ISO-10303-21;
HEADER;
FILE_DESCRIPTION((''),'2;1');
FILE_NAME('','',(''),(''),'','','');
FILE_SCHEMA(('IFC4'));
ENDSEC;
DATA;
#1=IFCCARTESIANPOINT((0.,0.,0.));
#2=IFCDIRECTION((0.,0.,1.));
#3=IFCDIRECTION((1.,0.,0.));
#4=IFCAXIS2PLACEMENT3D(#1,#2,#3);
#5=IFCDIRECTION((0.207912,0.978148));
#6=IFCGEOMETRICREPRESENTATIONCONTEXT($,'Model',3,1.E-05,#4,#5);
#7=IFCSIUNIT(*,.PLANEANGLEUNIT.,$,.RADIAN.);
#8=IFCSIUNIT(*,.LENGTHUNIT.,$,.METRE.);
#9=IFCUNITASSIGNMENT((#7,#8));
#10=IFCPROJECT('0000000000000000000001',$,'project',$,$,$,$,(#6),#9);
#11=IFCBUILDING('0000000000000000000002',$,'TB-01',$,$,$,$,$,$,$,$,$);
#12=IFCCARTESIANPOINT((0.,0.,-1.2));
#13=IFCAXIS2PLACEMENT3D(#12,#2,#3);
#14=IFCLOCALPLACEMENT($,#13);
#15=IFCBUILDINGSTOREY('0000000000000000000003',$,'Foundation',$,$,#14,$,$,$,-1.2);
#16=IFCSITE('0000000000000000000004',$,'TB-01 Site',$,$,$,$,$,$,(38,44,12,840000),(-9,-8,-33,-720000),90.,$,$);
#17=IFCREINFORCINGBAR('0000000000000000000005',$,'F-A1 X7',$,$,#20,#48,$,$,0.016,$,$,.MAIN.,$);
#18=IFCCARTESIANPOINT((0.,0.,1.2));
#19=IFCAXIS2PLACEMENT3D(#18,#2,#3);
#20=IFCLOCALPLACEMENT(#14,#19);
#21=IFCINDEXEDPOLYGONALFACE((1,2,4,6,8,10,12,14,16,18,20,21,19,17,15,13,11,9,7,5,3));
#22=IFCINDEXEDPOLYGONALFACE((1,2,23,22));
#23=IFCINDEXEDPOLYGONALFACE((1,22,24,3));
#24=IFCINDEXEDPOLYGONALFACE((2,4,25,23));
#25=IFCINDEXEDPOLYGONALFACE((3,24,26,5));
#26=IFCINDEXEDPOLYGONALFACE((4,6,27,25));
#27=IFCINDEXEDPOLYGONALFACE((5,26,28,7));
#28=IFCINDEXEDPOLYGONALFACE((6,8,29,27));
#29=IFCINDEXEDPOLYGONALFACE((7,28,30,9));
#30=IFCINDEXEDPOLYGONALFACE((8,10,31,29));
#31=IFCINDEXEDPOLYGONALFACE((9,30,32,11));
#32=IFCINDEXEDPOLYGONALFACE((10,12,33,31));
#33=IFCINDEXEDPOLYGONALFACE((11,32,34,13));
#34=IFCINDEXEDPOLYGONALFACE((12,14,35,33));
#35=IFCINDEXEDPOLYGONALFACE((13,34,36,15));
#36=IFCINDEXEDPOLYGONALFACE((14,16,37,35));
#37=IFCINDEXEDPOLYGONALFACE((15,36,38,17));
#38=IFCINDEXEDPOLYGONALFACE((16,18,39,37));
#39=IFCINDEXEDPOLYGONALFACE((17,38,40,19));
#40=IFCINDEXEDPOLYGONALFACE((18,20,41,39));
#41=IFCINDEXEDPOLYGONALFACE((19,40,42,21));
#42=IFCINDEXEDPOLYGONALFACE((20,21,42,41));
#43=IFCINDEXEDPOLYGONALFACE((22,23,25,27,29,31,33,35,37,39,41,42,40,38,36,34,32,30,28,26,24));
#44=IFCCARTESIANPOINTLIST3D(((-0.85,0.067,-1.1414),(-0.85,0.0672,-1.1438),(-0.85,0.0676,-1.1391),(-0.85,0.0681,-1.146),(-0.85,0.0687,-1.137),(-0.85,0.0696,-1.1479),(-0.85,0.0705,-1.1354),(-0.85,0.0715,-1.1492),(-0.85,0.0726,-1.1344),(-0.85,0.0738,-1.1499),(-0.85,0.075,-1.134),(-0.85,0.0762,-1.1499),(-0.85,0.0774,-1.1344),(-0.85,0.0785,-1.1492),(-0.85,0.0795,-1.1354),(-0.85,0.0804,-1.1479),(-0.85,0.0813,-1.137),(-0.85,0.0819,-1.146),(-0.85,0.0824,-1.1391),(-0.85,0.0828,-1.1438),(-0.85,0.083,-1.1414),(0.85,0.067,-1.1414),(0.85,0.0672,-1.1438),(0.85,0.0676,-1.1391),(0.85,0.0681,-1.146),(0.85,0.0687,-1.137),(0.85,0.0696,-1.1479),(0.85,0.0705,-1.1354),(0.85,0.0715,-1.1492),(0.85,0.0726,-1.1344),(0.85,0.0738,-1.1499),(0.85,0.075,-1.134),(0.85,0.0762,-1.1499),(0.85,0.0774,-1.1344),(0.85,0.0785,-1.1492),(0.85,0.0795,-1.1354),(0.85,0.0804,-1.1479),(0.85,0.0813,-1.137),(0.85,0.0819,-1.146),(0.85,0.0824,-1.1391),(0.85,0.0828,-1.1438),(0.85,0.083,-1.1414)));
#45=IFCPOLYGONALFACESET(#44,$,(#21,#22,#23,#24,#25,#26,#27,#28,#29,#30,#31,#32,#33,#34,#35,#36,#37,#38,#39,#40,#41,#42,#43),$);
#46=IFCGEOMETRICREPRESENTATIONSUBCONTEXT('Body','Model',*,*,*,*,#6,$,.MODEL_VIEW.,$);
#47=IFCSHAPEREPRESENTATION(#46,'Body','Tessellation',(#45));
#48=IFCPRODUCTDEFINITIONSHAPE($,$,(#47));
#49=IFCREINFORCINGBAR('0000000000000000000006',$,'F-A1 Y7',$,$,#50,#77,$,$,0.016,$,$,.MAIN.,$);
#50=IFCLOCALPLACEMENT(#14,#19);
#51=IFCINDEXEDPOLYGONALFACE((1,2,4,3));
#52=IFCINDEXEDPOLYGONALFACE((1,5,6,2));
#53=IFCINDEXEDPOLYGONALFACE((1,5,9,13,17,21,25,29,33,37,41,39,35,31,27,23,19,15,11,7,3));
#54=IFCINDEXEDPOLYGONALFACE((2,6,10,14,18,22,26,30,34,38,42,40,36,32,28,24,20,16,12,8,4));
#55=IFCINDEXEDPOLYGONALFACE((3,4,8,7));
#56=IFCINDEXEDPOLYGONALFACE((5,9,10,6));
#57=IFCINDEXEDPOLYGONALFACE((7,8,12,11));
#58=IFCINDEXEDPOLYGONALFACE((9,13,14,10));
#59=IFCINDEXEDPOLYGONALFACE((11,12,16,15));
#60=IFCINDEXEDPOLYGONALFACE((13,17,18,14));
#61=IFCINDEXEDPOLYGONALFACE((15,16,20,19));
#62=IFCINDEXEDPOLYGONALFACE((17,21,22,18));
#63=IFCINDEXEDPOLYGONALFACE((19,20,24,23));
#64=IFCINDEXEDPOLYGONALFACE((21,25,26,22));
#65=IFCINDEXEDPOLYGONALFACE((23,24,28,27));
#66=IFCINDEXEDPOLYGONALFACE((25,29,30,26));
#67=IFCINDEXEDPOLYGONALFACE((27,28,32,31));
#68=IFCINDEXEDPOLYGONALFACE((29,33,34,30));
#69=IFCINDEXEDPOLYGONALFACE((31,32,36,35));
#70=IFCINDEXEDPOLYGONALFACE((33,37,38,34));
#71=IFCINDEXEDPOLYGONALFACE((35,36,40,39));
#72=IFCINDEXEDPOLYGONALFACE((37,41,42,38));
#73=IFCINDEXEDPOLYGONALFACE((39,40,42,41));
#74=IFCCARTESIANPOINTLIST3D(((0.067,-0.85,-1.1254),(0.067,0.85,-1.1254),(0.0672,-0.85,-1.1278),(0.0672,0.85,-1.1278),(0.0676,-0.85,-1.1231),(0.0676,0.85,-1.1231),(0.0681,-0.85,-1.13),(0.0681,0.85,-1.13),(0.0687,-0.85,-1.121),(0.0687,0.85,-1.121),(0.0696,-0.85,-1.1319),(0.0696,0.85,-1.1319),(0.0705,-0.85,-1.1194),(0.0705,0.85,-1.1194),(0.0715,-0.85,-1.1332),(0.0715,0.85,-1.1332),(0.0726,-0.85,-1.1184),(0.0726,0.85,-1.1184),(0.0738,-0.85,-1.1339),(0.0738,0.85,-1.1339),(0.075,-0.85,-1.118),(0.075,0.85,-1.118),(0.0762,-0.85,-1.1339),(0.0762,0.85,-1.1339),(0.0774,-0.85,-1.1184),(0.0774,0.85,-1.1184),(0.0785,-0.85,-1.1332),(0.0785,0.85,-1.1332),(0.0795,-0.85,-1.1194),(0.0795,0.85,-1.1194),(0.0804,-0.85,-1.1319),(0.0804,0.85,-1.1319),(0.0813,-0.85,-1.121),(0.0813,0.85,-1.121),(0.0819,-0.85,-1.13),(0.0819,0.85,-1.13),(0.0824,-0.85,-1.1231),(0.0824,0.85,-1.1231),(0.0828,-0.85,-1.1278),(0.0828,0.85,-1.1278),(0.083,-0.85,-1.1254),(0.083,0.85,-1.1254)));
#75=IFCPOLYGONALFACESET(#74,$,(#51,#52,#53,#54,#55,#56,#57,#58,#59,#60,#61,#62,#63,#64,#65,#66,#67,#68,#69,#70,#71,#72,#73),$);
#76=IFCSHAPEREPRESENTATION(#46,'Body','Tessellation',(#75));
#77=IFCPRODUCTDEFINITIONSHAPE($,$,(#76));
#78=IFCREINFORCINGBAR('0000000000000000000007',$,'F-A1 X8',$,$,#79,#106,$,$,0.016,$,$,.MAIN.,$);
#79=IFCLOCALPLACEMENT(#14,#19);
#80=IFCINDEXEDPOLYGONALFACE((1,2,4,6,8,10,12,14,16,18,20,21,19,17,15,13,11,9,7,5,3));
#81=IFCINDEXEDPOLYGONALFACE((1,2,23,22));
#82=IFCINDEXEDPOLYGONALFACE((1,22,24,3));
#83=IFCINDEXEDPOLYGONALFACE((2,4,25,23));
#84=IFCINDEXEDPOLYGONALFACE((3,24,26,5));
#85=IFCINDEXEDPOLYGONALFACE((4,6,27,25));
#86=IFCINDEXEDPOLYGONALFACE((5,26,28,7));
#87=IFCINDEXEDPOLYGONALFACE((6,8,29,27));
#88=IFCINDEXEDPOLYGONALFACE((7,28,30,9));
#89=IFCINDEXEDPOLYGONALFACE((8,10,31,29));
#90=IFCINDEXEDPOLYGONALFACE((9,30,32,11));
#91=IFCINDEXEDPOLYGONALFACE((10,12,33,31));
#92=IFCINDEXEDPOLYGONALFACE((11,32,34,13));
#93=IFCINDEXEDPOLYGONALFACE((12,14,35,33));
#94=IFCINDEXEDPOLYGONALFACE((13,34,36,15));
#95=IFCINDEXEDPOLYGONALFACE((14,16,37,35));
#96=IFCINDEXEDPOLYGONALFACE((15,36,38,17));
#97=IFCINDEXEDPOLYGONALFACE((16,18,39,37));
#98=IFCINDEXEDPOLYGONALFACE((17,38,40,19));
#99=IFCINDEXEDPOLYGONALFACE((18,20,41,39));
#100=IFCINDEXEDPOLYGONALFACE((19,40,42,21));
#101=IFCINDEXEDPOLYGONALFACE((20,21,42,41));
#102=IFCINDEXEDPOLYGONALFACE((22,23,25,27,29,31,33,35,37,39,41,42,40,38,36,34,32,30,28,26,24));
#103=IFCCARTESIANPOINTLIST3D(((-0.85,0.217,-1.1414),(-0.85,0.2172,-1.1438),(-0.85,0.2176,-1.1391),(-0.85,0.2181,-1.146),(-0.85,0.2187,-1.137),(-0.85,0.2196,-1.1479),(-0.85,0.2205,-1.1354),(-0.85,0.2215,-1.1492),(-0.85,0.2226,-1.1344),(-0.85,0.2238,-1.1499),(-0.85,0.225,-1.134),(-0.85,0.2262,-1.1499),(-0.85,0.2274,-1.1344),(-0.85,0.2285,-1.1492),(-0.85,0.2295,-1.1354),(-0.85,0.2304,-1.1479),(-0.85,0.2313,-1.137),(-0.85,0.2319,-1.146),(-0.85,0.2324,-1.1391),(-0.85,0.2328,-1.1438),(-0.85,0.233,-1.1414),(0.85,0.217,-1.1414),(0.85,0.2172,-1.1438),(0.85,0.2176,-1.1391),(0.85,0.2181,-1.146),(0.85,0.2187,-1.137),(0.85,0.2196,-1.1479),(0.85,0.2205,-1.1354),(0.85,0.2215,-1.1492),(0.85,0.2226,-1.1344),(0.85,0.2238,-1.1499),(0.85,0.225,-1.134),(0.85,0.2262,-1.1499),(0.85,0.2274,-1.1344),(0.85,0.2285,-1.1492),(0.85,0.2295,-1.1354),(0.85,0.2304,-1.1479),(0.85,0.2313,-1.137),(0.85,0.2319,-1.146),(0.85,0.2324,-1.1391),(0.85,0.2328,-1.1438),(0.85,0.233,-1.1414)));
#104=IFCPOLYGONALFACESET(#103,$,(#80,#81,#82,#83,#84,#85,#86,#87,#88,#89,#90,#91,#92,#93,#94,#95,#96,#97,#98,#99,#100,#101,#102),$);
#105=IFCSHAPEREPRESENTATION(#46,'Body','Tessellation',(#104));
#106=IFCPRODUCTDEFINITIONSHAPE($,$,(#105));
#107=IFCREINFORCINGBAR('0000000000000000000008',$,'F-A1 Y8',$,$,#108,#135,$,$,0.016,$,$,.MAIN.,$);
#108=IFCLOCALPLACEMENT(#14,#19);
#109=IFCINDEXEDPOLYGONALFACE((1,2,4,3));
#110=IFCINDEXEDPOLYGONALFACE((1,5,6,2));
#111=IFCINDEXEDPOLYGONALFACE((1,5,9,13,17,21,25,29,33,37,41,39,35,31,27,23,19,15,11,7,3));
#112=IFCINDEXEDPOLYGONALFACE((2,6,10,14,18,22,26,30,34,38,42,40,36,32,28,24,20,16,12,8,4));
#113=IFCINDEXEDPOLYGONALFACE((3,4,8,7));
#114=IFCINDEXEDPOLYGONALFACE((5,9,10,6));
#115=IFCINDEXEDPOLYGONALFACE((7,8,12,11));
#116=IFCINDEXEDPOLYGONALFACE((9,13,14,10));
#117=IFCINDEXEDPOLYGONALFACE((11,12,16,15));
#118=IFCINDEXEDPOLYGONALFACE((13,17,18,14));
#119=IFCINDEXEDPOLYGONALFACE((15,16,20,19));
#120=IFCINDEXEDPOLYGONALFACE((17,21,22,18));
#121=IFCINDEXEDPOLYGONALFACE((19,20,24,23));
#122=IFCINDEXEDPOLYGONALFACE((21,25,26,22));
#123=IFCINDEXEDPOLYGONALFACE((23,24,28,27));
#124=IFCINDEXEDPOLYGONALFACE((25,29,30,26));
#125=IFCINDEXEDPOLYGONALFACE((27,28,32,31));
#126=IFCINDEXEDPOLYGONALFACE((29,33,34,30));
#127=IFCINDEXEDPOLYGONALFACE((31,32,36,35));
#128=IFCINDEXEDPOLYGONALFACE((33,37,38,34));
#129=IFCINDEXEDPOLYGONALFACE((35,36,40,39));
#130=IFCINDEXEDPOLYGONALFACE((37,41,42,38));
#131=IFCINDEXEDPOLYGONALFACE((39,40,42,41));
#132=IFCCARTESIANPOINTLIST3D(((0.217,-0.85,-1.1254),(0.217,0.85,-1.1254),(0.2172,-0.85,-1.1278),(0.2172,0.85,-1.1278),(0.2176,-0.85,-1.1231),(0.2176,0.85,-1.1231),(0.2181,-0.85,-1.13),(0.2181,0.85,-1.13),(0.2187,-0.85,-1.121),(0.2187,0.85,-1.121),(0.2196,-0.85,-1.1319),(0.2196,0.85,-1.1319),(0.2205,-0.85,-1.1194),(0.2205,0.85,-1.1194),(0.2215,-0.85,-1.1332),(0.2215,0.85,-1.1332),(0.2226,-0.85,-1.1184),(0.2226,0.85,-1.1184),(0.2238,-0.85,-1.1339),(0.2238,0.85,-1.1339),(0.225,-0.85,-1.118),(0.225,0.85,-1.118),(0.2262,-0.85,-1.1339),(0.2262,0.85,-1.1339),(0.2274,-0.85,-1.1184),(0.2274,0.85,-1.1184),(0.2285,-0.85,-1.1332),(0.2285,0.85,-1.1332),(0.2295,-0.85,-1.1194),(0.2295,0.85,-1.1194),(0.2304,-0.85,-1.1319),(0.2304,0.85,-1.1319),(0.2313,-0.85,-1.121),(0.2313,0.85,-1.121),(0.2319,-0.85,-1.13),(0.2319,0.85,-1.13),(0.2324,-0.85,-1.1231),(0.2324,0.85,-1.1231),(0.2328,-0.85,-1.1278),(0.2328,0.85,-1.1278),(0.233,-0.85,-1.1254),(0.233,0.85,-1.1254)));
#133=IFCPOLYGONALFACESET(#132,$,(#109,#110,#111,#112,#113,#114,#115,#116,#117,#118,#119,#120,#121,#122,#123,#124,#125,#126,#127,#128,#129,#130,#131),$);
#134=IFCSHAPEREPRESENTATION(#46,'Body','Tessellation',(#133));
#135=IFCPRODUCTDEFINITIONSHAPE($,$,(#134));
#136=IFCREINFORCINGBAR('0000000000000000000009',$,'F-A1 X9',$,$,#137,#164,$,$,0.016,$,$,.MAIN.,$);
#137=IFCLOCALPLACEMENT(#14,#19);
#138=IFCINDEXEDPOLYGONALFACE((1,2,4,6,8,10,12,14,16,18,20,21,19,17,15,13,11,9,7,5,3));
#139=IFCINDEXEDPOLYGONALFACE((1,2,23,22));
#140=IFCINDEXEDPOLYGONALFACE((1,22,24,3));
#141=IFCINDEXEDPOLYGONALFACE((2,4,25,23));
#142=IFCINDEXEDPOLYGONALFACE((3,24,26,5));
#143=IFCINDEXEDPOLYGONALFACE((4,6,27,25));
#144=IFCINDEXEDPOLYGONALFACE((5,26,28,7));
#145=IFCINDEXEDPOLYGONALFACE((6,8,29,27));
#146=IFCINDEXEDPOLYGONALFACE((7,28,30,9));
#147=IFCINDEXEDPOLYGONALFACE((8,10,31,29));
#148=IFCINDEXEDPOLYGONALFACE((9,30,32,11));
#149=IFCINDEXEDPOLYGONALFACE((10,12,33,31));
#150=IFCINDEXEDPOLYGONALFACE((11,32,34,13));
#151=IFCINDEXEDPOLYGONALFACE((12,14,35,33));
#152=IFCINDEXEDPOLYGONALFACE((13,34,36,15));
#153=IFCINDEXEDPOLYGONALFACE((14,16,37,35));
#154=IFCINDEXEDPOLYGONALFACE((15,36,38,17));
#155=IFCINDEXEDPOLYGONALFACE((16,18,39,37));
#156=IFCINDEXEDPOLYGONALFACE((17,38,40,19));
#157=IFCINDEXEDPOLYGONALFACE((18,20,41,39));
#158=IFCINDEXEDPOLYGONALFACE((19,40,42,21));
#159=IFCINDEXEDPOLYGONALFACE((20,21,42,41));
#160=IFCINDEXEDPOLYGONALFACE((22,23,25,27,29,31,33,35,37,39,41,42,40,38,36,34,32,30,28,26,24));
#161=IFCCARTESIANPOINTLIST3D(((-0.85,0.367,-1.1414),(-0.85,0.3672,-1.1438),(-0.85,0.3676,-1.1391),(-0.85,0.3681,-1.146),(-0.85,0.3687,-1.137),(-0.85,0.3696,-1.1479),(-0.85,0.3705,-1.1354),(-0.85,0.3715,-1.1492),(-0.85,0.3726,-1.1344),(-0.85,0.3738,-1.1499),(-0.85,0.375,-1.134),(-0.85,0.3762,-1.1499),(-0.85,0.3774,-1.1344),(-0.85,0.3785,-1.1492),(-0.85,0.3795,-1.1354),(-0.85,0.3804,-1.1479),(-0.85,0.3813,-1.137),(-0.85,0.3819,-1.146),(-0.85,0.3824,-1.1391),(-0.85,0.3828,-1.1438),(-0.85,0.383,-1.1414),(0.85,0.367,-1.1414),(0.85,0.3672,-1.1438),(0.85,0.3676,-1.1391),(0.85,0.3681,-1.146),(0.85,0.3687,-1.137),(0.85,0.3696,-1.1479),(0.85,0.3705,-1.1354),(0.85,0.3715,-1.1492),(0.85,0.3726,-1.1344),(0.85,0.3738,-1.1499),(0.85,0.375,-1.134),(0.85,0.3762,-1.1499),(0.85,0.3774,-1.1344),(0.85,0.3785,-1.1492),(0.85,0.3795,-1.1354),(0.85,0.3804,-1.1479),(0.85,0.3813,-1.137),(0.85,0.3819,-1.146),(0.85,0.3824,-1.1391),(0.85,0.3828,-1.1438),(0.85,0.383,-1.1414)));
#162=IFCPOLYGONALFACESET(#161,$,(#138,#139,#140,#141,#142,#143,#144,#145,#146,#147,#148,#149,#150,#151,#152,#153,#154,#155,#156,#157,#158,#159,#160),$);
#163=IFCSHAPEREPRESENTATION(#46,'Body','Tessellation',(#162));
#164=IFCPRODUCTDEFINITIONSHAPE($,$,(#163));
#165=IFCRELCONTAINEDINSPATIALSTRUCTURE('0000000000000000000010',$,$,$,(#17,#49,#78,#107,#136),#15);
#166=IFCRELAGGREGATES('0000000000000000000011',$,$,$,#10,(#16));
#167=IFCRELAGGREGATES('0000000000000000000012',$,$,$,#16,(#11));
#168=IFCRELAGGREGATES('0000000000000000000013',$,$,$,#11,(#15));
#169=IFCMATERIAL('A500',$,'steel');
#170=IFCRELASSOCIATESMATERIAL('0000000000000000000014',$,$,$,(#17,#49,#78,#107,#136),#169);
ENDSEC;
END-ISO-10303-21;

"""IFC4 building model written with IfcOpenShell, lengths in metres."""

from ifc_helpers import new_model, entity, si_unit, direction, frame, origin_with_axes, place, context, subcontext, project, spatial, material, element, save


model = new_model("IFC4")

# Units and contexts
model_context = context("Model", 3, precision=1e-05, world=origin_with_axes(), true_north=direction((0.207912, 0.978148)))
body_context = subcontext(model_context, "Body", "Model", "MODEL_VIEW")
ifc_project = project(units=[si_unit("PLANEANGLEUNIT", "RADIAN"), si_unit("LENGTHUNIT", "METRE")], contexts=[model_context])

# Site, building, storey
site = spatial("IfcSite", under=ifc_project, Name="TB-01 Site", RefLatitude=(38, 44, 12, 840000), RefLongitude=(-9, -8, -33, -720000), RefElevation=90.0)
building = spatial("IfcBuilding", under=site, Name="TB-01")
storey_placement = place(None, frame((0.0, 0.0, -1.2), z_axis=(0.0, 0.0, 1.0), x_axis=(1.0, 0.0, 0.0)))
storey = spatial("IfcBuildingStorey", under=building, at=storey_placement, Name="Foundation", Elevation=-1.2)

# Reinforcing bars
ifc_material_1 = material(Name="A500", Category="steel")
reinforcing_bar_1_placement = place(storey_placement, frame((0.0, 0.0, 1.2), z_axis=(0.0, 0.0, 1.0), x_axis=(1.0, 0.0, 0.0)))
element("IfcReinforcingBar", 1, at=reinforcing_bar_1_placement, inside=storey, material=ifc_material_1, Name="F-A1 X7", NominalDiameter=0.016, PredefinedType="MAIN", context=body_context, shape_type="AdvancedSweptSolid", body=[
    entity("IfcSweptDiskSolid", entity("IfcPolyline", [entity("IfcCartesianPoint", [-0.85, 0.075, -1.142]), entity("IfcCartesianPoint", [0.85, 0.075, -1.142])]), 0.008),
])
reinforcing_bar_2_placement = place(storey_placement, frame((0.0, 0.0, 1.2), z_axis=(0.0, 0.0, 1.0), x_axis=(1.0, 0.0, 0.0)))
element("IfcReinforcingBar", 2, at=reinforcing_bar_2_placement, inside=storey, material=ifc_material_1, Name="F-A1 Y7", NominalDiameter=0.016, PredefinedType="MAIN", context=body_context, shape_type="AdvancedSweptSolid", body=[
    entity("IfcSweptDiskSolid", entity("IfcPolyline", [entity("IfcCartesianPoint", [0.075, -0.85, -1.126]), entity("IfcCartesianPoint", [0.075, 0.85, -1.126])]), 0.008),
])
reinforcing_bar_3_placement = place(storey_placement, frame((0.0, 0.0, 1.2), z_axis=(0.0, 0.0, 1.0), x_axis=(1.0, 0.0, 0.0)))
element("IfcReinforcingBar", 3, at=reinforcing_bar_3_placement, inside=storey, material=ifc_material_1, Name="F-A1 X8", NominalDiameter=0.016, PredefinedType="MAIN", context=body_context, shape_type="AdvancedSweptSolid", body=[
    entity("IfcSweptDiskSolid", entity("IfcPolyline", [entity("IfcCartesianPoint", [-0.85, 0.225, -1.142]), entity("IfcCartesianPoint", [0.85, 0.225, -1.142])]), 0.008),
])
reinforcing_bar_4_placement = place(storey_placement, frame((0.0, 0.0, 1.2), z_axis=(0.0, 0.0, 1.0), x_axis=(1.0, 0.0, 0.0)))
element("IfcReinforcingBar", 4, at=reinforcing_bar_4_placement, inside=storey, material=ifc_material_1, Name="F-A1 Y8", NominalDiameter=0.016, PredefinedType="MAIN", context=body_context, shape_type="AdvancedSweptSolid", body=[
    entity("IfcSweptDiskSolid", entity("IfcPolyline", [entity("IfcCartesianPoint", [0.225, -0.85, -1.126]), entity("IfcCartesianPoint", [0.225, 0.85, -1.126])]), 0.008),
])
reinforcing_bar_5_placement = place(storey_placement, frame((0.0, 0.0, 1.2), z_axis=(0.0, 0.0, 1.0), x_axis=(1.0, 0.0, 0.0)))
element("IfcReinforcingBar", 5, at=reinforcing_bar_5_placement, inside=storey, material=ifc_material_1, Name="F-A1 X9", NominalDiameter=0.016, PredefinedType="MAIN", context=body_context, shape_type="AdvancedSweptSolid", body=[
    entity("IfcSweptDiskSolid", entity("IfcPolyline", [entity("IfcCartesianPoint", [-0.85, 0.375, -1.142]), entity("IfcCartesianPoint", [0.85, 0.375, -1.142])]), 0.008),
])

save(model, "model.ifc")
